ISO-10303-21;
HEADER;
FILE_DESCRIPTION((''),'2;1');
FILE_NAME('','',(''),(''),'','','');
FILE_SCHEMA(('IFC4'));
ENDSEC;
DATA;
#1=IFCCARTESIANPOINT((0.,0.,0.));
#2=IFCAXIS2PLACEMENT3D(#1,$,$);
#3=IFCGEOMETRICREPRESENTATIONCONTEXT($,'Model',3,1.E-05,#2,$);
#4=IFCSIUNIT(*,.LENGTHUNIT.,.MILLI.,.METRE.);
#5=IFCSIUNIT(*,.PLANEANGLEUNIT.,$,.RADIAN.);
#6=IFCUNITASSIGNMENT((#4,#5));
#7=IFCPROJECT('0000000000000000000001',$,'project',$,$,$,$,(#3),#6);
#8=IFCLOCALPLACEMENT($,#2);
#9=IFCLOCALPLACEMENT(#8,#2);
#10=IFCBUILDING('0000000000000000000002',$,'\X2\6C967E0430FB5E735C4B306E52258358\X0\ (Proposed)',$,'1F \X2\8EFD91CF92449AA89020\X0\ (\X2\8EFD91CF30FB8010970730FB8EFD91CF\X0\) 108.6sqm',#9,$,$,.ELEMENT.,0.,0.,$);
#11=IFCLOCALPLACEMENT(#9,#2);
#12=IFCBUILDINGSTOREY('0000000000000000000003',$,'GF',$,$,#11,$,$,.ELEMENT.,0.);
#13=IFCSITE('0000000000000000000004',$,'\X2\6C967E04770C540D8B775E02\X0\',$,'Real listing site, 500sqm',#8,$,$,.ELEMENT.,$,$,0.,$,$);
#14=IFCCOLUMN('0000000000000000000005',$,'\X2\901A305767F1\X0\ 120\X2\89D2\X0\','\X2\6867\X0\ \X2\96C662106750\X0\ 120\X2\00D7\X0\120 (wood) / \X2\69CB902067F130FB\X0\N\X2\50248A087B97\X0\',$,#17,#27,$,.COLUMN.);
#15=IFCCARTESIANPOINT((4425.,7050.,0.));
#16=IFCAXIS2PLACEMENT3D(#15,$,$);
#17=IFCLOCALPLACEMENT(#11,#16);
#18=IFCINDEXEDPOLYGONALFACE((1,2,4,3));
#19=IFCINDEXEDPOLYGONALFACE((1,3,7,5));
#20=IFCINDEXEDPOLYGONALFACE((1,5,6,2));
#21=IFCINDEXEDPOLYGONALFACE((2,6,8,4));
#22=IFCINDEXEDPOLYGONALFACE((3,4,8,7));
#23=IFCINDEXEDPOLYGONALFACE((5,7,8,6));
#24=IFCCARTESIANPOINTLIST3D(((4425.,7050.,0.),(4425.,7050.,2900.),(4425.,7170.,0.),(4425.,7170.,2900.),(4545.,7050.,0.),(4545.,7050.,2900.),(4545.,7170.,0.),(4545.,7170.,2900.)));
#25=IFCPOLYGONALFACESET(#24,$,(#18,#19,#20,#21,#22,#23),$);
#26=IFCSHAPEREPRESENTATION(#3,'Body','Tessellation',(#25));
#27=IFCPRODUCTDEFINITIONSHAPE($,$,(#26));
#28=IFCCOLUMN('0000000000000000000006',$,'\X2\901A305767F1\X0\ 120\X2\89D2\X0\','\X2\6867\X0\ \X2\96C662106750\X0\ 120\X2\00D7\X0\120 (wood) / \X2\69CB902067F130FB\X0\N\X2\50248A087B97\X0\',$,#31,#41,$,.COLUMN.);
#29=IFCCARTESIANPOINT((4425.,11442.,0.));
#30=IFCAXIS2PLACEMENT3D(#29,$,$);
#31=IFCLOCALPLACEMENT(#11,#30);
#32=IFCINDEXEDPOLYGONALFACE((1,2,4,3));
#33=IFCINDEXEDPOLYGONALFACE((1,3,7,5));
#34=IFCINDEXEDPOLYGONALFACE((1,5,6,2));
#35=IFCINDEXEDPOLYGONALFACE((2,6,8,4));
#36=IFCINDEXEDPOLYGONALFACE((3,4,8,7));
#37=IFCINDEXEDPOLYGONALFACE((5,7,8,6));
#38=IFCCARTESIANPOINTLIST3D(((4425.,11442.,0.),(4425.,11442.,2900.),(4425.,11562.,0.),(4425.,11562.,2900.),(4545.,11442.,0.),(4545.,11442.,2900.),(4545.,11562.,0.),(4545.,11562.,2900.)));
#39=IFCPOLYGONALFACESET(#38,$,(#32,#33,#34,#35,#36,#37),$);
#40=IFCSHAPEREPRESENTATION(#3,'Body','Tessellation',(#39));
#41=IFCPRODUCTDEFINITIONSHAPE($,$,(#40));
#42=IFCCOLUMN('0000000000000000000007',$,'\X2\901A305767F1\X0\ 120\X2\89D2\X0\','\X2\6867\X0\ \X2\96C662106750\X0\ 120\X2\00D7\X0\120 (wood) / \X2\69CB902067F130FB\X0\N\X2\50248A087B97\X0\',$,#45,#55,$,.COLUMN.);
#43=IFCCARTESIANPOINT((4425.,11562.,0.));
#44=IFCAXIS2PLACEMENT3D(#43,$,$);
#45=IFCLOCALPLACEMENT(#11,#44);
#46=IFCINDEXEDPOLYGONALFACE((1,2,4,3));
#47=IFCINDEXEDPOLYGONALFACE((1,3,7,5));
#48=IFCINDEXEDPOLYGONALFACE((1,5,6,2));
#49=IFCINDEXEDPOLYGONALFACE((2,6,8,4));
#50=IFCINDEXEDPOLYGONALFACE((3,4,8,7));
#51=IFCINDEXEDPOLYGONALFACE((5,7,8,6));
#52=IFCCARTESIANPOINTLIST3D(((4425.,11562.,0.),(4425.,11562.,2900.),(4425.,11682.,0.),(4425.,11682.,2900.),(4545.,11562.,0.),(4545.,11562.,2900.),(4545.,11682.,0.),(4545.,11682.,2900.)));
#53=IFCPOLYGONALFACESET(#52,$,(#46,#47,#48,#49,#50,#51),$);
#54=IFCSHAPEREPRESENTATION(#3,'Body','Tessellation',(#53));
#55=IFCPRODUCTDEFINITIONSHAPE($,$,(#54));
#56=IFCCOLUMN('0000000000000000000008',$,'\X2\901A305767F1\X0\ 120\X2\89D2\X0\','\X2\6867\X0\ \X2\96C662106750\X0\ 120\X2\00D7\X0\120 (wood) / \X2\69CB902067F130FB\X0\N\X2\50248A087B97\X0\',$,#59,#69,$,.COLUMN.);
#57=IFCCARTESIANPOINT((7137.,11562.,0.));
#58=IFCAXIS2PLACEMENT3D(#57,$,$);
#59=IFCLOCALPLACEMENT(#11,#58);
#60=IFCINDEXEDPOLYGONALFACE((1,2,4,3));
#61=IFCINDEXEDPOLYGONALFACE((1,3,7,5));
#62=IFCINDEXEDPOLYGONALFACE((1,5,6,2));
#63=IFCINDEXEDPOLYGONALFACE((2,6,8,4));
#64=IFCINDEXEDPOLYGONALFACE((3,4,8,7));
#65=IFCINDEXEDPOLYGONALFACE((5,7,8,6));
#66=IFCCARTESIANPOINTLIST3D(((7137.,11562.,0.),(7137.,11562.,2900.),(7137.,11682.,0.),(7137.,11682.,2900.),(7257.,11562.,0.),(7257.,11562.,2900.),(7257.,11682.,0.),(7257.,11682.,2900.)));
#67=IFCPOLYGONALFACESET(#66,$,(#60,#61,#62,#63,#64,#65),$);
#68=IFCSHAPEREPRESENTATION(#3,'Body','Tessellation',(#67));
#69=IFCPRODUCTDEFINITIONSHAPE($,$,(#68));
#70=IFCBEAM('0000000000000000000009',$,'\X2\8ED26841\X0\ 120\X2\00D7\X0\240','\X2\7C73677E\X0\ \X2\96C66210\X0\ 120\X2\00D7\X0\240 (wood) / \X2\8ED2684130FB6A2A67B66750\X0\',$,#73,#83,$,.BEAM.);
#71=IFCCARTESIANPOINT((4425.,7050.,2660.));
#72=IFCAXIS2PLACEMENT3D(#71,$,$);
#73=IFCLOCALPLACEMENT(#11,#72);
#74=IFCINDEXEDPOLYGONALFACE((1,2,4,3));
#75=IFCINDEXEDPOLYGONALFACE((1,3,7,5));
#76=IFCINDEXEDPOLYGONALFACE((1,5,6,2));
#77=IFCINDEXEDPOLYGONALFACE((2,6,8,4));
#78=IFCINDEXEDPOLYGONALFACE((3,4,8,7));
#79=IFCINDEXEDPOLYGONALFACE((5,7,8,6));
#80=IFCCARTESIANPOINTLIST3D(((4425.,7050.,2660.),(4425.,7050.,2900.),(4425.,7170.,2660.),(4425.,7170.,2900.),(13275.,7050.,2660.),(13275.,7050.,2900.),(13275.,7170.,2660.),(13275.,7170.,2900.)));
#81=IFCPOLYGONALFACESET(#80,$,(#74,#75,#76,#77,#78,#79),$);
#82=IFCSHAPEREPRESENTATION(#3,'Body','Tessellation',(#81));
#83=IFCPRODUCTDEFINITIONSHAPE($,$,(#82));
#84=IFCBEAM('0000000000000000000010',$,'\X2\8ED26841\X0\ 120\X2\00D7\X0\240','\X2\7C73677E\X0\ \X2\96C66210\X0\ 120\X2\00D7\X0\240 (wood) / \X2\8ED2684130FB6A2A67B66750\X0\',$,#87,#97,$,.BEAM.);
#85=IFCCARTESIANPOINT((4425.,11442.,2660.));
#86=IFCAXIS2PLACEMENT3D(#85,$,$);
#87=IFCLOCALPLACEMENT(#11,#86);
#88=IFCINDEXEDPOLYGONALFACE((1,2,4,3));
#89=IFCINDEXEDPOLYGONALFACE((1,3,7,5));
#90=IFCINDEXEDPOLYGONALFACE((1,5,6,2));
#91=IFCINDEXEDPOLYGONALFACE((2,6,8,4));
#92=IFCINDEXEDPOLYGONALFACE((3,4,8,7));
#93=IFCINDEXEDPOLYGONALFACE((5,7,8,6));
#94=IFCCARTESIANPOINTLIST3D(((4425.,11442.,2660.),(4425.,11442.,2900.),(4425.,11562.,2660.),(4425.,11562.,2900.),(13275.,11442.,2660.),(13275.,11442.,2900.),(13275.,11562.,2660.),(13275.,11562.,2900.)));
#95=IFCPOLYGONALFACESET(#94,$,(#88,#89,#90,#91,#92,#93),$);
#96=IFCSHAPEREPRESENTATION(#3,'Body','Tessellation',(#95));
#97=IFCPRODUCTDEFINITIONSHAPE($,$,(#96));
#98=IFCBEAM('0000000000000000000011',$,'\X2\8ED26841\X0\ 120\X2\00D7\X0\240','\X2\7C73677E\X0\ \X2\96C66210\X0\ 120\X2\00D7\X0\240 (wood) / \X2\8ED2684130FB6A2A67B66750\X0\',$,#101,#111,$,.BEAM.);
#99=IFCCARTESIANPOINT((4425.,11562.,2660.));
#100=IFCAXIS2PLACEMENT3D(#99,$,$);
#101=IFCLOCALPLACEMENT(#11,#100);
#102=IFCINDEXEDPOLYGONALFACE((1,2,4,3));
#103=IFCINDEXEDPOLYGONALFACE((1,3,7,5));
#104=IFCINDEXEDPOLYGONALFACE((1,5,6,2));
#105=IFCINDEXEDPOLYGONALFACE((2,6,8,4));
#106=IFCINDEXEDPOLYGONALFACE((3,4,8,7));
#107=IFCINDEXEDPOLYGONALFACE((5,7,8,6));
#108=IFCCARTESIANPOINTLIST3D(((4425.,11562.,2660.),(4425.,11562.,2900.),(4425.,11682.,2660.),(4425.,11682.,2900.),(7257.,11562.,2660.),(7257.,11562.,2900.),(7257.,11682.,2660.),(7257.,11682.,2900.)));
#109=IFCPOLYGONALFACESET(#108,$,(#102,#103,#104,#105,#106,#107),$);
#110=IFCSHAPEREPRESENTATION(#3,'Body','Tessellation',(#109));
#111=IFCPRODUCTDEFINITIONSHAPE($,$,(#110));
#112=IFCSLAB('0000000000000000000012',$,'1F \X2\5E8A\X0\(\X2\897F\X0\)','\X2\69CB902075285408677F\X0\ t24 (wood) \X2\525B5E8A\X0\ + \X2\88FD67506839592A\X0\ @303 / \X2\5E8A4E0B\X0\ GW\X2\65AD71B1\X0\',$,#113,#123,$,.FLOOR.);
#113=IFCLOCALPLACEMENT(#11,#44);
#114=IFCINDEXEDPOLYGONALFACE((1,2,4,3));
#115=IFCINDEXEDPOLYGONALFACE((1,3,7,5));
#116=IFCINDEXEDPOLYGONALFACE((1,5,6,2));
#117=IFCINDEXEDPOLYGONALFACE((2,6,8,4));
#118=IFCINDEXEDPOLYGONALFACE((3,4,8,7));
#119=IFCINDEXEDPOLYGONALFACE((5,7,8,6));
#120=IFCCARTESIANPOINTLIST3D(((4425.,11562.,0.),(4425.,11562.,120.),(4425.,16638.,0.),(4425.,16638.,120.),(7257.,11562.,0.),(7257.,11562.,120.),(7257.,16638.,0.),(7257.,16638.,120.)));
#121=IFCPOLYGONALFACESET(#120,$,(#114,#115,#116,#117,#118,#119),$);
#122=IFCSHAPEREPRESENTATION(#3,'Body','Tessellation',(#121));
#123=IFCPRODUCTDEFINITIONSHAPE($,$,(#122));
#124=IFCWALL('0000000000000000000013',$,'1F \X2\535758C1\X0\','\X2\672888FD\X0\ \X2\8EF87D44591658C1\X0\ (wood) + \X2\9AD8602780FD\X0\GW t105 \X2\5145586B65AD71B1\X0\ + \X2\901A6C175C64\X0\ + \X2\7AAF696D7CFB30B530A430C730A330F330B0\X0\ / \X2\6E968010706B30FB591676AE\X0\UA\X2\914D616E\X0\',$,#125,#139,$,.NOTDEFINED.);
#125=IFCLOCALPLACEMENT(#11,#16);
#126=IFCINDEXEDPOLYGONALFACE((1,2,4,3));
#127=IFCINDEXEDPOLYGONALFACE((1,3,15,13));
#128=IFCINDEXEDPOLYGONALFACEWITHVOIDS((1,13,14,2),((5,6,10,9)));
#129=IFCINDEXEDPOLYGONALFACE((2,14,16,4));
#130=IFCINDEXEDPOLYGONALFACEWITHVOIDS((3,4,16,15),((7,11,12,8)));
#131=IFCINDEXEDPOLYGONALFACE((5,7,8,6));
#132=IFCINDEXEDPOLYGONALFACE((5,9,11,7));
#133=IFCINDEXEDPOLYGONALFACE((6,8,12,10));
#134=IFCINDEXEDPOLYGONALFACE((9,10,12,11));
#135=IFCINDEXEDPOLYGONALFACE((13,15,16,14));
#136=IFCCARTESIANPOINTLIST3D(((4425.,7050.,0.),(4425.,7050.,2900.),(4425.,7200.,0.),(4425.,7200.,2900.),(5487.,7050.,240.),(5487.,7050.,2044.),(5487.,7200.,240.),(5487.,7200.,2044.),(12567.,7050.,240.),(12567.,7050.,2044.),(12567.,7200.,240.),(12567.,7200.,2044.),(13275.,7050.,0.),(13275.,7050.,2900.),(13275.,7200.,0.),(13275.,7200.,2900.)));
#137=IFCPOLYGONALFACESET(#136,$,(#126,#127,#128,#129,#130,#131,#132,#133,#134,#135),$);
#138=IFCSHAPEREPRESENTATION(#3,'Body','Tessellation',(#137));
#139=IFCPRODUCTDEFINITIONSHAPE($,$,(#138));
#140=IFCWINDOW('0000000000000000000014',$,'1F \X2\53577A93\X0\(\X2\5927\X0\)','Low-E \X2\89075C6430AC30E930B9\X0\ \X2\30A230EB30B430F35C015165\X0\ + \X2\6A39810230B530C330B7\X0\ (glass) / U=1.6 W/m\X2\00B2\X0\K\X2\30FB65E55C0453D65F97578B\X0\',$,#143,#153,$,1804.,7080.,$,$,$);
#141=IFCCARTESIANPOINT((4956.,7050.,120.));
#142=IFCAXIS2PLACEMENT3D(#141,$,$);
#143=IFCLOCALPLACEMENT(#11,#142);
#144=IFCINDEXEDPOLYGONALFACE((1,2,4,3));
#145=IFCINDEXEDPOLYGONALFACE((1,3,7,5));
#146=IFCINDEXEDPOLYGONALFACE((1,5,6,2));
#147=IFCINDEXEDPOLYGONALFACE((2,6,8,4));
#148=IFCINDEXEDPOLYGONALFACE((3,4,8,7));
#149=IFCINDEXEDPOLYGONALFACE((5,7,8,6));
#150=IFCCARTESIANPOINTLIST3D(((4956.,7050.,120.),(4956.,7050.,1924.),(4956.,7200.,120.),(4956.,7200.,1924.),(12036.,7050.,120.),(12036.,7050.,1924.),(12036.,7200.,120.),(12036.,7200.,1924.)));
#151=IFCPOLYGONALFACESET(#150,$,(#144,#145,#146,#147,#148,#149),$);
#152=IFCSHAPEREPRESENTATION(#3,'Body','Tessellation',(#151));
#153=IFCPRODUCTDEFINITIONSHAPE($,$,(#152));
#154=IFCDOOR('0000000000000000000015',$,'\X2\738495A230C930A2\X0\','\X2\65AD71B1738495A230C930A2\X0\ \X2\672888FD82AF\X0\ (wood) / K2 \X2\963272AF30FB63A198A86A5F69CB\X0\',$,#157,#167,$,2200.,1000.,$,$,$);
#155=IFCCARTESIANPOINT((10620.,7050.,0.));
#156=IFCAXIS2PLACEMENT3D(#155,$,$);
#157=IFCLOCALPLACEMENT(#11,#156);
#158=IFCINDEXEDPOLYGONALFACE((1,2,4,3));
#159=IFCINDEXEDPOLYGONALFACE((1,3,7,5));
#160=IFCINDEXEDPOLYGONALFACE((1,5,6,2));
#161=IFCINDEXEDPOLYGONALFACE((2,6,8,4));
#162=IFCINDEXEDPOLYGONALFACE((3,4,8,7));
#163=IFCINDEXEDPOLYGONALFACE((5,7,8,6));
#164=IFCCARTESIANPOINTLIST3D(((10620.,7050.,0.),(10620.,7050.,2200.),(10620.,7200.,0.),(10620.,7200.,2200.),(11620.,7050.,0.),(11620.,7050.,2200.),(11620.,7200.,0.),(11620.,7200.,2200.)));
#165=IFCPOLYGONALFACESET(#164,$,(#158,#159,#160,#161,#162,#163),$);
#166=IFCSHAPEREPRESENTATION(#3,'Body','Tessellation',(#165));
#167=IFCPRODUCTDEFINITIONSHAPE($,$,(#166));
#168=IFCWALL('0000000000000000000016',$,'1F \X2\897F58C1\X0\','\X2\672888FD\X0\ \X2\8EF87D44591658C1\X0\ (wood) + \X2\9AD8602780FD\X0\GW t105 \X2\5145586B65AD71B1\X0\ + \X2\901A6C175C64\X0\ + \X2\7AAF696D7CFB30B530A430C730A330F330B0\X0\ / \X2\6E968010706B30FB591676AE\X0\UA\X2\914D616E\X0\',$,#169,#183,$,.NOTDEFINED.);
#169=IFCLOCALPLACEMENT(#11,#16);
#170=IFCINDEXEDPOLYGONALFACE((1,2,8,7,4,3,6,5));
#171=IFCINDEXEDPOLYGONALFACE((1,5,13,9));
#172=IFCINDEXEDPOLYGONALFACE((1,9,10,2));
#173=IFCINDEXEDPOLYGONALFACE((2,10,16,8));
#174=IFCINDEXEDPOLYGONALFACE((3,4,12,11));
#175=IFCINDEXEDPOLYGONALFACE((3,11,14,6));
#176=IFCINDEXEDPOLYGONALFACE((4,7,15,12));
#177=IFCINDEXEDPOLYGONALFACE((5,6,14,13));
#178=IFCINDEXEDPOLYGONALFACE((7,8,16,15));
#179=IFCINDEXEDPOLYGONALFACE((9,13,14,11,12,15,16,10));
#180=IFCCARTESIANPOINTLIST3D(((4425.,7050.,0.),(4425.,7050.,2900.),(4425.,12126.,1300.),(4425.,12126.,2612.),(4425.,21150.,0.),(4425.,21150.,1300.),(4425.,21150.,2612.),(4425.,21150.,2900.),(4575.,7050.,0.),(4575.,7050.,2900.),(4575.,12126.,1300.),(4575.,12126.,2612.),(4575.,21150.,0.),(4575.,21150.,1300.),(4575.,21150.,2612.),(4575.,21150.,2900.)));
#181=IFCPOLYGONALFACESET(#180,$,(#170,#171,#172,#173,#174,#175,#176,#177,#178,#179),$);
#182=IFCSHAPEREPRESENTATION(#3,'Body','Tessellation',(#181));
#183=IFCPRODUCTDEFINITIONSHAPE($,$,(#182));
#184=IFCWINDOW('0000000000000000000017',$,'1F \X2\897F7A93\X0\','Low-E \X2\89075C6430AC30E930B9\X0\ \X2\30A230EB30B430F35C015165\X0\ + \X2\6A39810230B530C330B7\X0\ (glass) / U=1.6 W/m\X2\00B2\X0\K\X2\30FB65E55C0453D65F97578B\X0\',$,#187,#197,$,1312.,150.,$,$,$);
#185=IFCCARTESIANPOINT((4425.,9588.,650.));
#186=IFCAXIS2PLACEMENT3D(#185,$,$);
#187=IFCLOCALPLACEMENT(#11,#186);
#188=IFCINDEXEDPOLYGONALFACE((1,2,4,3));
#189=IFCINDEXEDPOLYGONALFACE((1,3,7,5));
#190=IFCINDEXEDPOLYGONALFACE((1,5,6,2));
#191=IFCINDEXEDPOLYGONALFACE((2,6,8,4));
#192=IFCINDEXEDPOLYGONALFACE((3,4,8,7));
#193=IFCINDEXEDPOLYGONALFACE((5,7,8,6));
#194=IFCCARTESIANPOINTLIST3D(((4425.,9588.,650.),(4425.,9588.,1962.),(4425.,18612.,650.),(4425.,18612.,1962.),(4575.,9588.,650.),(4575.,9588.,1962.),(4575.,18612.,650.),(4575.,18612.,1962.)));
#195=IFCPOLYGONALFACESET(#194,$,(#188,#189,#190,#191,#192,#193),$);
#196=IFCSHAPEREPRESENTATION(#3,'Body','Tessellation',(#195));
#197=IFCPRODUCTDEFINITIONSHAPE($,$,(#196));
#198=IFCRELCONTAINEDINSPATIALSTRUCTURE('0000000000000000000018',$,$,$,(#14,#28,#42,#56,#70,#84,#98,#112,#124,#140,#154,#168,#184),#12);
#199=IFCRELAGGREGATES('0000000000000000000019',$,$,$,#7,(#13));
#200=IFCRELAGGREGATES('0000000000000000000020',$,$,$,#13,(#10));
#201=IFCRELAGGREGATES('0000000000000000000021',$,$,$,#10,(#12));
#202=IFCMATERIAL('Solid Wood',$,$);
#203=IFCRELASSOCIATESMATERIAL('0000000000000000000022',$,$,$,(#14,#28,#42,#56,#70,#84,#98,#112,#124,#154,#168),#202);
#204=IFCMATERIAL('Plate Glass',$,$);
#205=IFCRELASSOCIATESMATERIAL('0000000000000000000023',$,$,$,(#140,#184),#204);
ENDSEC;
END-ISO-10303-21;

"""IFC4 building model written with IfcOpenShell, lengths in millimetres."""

from ifc_helpers import new_model, si_unit, frame, frame_2d, origin, place, context, project, spatial, rectangle, extrude, material, element, fill, save


model = new_model("IFC4")

# Units and contexts
model_context = context("Model", 3, precision=1e-05, world=origin())
ifc_project = project(units=[si_unit("LENGTHUNIT", "METRE", prefix="MILLI"), si_unit("PLANEANGLEUNIT", "RADIAN")], contexts=[model_context])

# Site, building, storey
site_placement = place(None, origin())
site = spatial("IfcSite", under=ifc_project, at=site_placement, Name="沖縄県名護市", ObjectType="Real listing site, 500sqm", CompositionType="ELEMENT", RefElevation=0.0)
building_placement = place(site_placement, origin())
building = spatial("IfcBuilding", under=site, at=building_placement, Name="沖縄・平屋の別荘 (Proposed)", ObjectType="1F 軽量鉄骨造 (軽量・耐震・軽量) 108.6sqm", CompositionType="ELEMENT", ElevationOfRefHeight=0.0, ElevationOfTerrain=0.0)
storey_placement = place(building_placement, origin())
storey = spatial("IfcBuildingStorey", under=building, at=storey_placement, Name="GF", CompositionType="ELEMENT", Elevation=0.0)

# Columns
ifc_material_1 = material(Name="Solid Wood")
column_1_placement = place(storey_placement, frame((4425.0, 7050.0, 0.0)))
element("IfcColumn", 1, at=column_1_placement, inside=storey, material=ifc_material_1, Name="通し柱 120角", Description="桧 集成材 120×120 (wood) / 構造柱・N値計算", PredefinedType="COLUMN", context=model_context, shape_type="SweptSolid", body=[
    extrude(rectangle(XDim=120.0, YDim=120.0, at=frame_2d((60.0, 60.0))), frame((4425.0, 7050.0, 0.0)), (0.0, 0.0, 1.0), 2900.0),
])
column_2_placement = place(storey_placement, frame((4425.0, 11442.0, 0.0)))
element("IfcColumn", 2, at=column_2_placement, inside=storey, material=ifc_material_1, Name="通し柱 120角", Description="桧 集成材 120×120 (wood) / 構造柱・N値計算", PredefinedType="COLUMN", context=model_context, shape_type="SweptSolid", body=[
    extrude(rectangle(XDim=120.0, YDim=120.0, at=frame_2d((60.0, 60.0))), frame((4425.0, 11442.0, 0.0)), (0.0, 0.0, 1.0), 2900.0),
])
column_3_placement = place(storey_placement, frame((4425.0, 11562.0, 0.0)))
element("IfcColumn", 3, at=column_3_placement, inside=storey, material=ifc_material_1, Name="通し柱 120角", Description="桧 集成材 120×120 (wood) / 構造柱・N値計算", PredefinedType="COLUMN", context=model_context, shape_type="SweptSolid", body=[
    extrude(rectangle(XDim=120.0, YDim=120.0, at=frame_2d((60.0, 60.0))), frame((4425.0, 11562.0, 0.0)), (0.0, 0.0, 1.0), 2900.0),
])
column_4_placement = place(storey_placement, frame((7137.0, 11562.0, 0.0)))
element("IfcColumn", 4, at=column_4_placement, inside=storey, material=ifc_material_1, Name="通し柱 120角", Description="桧 集成材 120×120 (wood) / 構造柱・N値計算", PredefinedType="COLUMN", context=model_context, shape_type="SweptSolid", body=[
    extrude(rectangle(XDim=120.0, YDim=120.0, at=frame_2d((60.0, 60.0))), frame((7137.0, 11562.0, 0.0)), (0.0, 0.0, 1.0), 2900.0),
])

# Beams
beam_1_placement = place(storey_placement, frame((4425.0, 7050.0, 2660.0)))
element("IfcBeam", 5, at=beam_1_placement, inside=storey, material=ifc_material_1, Name="軒桁 120×240", Description="米松 集成 120×240 (wood) / 軒桁・横架材", PredefinedType="BEAM", context=model_context, shape_type="SweptSolid", body=[
    extrude(rectangle(XDim=8850.0, YDim=120.0, at=frame_2d((4425.0, 60.0))), frame((4425.0, 7050.0, 2660.0)), (0.0, 0.0, 1.0), 240.0),
])
beam_2_placement = place(storey_placement, frame((4425.0, 11442.0, 2660.0)))
element("IfcBeam", 6, at=beam_2_placement, inside=storey, material=ifc_material_1, Name="軒桁 120×240", Description="米松 集成 120×240 (wood) / 軒桁・横架材", PredefinedType="BEAM", context=model_context, shape_type="SweptSolid", body=[
    extrude(rectangle(XDim=8850.0, YDim=120.0, at=frame_2d((4425.0, 60.0))), frame((4425.0, 11442.0, 2660.0)), (0.0, 0.0, 1.0), 240.0),
])
beam_3_placement = place(storey_placement, frame((4425.0, 11562.0, 2660.0)))
element("IfcBeam", 7, at=beam_3_placement, inside=storey, material=ifc_material_1, Name="軒桁 120×240", Description="米松 集成 120×240 (wood) / 軒桁・横架材", PredefinedType="BEAM", context=model_context, shape_type="SweptSolid", body=[
    extrude(rectangle(XDim=2832.0, YDim=120.0, at=frame_2d((1416.0, 60.0))), frame((4425.0, 11562.0, 2660.0)), (0.0, 0.0, 1.0), 240.0),
])

# Slab
slab_1_placement = place(storey_placement, frame((4425.0, 11562.0, 0.0)))
element("IfcSlab", 8, at=slab_1_placement, inside=storey, material=ifc_material_1, Name="1F 床(西)", Description="構造用合板 t24 (wood) 剛床 + 製材根太 @303 / 床下 GW断熱", PredefinedType="FLOOR", context=model_context, shape_type="SweptSolid", body=[
    extrude(rectangle(XDim=2832.0, YDim=5076.0, at=frame_2d((1416.0, 2538.0))), frame((4425.0, 11562.0, 0.0)), (0.0, 0.0, 1.0), 120.0),
])

# Wall, openings, window, door
wall_1_placement = place(storey_placement, frame((4425.0, 7050.0, 0.0)))
wall_1 = element("IfcWall", 9, at=wall_1_placement, inside=storey, material=ifc_material_1, Name="1F 南壁", Description="木製 軸組外壁 (wood) + 高性能GW t105 充填断熱 + 通気層 + 窯業系サイディング / 準耐火・外皮UA配慮", PredefinedType="NOTDEFINED", context=model_context, shape_type="SweptSolid", body=[
    extrude(rectangle(XDim=8850.0, YDim=150.0, at=frame_2d((4425.0, 75.0))), frame((4425.0, 7050.0, 0.0)), (0.0, 0.0, 1.0), 2900.0),
])
opening_1_placement = place(storey_placement, frame((4956.0, 7050.0, 120.0)))
opening_1 = element("IfcOpeningElement", 10, at=opening_1_placement, cuts=wall_1, PredefinedType="NOTDEFINED", context=model_context, shape_type="SweptSolid", body=[
    extrude(rectangle(XDim=7080.0, YDim=150.0, at=frame_2d((3540.0, 75.0))), frame((4956.0, 7050.0, 120.0)), (0.0, 0.0, 1.0), 1804.0),
])
opening_2_placement = place(storey_placement, frame((10620.0, 7050.0, 0.0)))
opening_2 = element("IfcOpeningElement", 11, at=opening_2_placement, cuts=wall_1, PredefinedType="NOTDEFINED", context=model_context, shape_type="SweptSolid", body=[
    extrude(rectangle(XDim=1000.0, YDim=150.0, at=frame_2d((500.0, 75.0))), frame((10620.0, 7050.0, 0.0)), (0.0, 0.0, 1.0), 2200.0),
])
ifc_material_2 = material(Name="Plate Glass")
window_1_placement = place(storey_placement, frame((4956.0, 7050.0, 120.0)))
window_1 = element("IfcWindow", 12, at=window_1_placement, inside=storey, material=ifc_material_2, Name="1F 南窓(大)", Description="Low-E 複層ガラス アルゴン封入 + 樹脂サッシ (glass) / U=1.6 W/m²K・日射取得型", OverallHeight=1804.0, OverallWidth=7080.0, context=model_context, shape_type="SweptSolid", body=[
    extrude(rectangle(XDim=7080.0, YDim=150.0, at=frame_2d((3540.0, 75.0))), frame((4956.0, 7050.0, 120.0)), (0.0, 0.0, 1.0), 1804.0),
])
fill(opening_1, window_1)
door_placement = place(storey_placement, frame((10620.0, 7050.0, 0.0)))
door = element("IfcDoor", 13, at=door_placement, inside=storey, material=ifc_material_1, Name="玄関ドア", Description="断熱玄関ドア 木製芯 (wood) / K2 防犯・採風機構", OverallHeight=2200.0, OverallWidth=1000.0, context=model_context, shape_type="SweptSolid", body=[
    extrude(rectangle(XDim=1000.0, YDim=150.0, at=frame_2d((500.0, 75.0))), frame((10620.0, 7050.0, 0.0)), (0.0, 0.0, 1.0), 2200.0),
])
fill(opening_2, door)

# Wall, opening, window
wall_2_placement = place(storey_placement, frame((4425.0, 7050.0, 0.0)))
wall_2 = element("IfcWall", 14, at=wall_2_placement, inside=storey, material=ifc_material_1, Name="1F 西壁", Description="木製 軸組外壁 (wood) + 高性能GW t105 充填断熱 + 通気層 + 窯業系サイディング / 準耐火・外皮UA配慮", PredefinedType="NOTDEFINED", context=model_context, shape_type="SweptSolid", body=[
    extrude(rectangle(XDim=150.0, YDim=14100.0, at=frame_2d((75.0, 7050.0))), frame((4425.0, 7050.0, 0.0)), (0.0, 0.0, 1.0), 2900.0),
])
opening_3_placement = place(storey_placement, frame((4425.0, 9588.0, 650.0)))
opening_3 = element("IfcOpeningElement", 15, at=opening_3_placement, cuts=wall_2, PredefinedType="NOTDEFINED", context=model_context, shape_type="SweptSolid", body=[
    extrude(rectangle(XDim=150.0, YDim=9024.0, at=frame_2d((75.0, 4512.0))), frame((4425.0, 9588.0, 650.0)), (0.0, 0.0, 1.0), 1312.0),
])
window_2_placement = place(storey_placement, frame((4425.0, 9588.0, 650.0)))
window_2 = element("IfcWindow", 16, at=window_2_placement, inside=storey, material=ifc_material_2, Name="1F 西窓", Description="Low-E 複層ガラス アルゴン封入 + 樹脂サッシ (glass) / U=1.6 W/m²K・日射取得型", OverallHeight=1312.0, OverallWidth=150.0, context=model_context, shape_type="SweptSolid", body=[
    extrude(rectangle(XDim=150.0, YDim=9024.0, at=frame_2d((75.0, 4512.0))), frame((4425.0, 9588.0, 650.0)), (0.0, 0.0, 1.0), 1312.0),
])
fill(opening_3, window_2)

save(model, "model.ifc")
